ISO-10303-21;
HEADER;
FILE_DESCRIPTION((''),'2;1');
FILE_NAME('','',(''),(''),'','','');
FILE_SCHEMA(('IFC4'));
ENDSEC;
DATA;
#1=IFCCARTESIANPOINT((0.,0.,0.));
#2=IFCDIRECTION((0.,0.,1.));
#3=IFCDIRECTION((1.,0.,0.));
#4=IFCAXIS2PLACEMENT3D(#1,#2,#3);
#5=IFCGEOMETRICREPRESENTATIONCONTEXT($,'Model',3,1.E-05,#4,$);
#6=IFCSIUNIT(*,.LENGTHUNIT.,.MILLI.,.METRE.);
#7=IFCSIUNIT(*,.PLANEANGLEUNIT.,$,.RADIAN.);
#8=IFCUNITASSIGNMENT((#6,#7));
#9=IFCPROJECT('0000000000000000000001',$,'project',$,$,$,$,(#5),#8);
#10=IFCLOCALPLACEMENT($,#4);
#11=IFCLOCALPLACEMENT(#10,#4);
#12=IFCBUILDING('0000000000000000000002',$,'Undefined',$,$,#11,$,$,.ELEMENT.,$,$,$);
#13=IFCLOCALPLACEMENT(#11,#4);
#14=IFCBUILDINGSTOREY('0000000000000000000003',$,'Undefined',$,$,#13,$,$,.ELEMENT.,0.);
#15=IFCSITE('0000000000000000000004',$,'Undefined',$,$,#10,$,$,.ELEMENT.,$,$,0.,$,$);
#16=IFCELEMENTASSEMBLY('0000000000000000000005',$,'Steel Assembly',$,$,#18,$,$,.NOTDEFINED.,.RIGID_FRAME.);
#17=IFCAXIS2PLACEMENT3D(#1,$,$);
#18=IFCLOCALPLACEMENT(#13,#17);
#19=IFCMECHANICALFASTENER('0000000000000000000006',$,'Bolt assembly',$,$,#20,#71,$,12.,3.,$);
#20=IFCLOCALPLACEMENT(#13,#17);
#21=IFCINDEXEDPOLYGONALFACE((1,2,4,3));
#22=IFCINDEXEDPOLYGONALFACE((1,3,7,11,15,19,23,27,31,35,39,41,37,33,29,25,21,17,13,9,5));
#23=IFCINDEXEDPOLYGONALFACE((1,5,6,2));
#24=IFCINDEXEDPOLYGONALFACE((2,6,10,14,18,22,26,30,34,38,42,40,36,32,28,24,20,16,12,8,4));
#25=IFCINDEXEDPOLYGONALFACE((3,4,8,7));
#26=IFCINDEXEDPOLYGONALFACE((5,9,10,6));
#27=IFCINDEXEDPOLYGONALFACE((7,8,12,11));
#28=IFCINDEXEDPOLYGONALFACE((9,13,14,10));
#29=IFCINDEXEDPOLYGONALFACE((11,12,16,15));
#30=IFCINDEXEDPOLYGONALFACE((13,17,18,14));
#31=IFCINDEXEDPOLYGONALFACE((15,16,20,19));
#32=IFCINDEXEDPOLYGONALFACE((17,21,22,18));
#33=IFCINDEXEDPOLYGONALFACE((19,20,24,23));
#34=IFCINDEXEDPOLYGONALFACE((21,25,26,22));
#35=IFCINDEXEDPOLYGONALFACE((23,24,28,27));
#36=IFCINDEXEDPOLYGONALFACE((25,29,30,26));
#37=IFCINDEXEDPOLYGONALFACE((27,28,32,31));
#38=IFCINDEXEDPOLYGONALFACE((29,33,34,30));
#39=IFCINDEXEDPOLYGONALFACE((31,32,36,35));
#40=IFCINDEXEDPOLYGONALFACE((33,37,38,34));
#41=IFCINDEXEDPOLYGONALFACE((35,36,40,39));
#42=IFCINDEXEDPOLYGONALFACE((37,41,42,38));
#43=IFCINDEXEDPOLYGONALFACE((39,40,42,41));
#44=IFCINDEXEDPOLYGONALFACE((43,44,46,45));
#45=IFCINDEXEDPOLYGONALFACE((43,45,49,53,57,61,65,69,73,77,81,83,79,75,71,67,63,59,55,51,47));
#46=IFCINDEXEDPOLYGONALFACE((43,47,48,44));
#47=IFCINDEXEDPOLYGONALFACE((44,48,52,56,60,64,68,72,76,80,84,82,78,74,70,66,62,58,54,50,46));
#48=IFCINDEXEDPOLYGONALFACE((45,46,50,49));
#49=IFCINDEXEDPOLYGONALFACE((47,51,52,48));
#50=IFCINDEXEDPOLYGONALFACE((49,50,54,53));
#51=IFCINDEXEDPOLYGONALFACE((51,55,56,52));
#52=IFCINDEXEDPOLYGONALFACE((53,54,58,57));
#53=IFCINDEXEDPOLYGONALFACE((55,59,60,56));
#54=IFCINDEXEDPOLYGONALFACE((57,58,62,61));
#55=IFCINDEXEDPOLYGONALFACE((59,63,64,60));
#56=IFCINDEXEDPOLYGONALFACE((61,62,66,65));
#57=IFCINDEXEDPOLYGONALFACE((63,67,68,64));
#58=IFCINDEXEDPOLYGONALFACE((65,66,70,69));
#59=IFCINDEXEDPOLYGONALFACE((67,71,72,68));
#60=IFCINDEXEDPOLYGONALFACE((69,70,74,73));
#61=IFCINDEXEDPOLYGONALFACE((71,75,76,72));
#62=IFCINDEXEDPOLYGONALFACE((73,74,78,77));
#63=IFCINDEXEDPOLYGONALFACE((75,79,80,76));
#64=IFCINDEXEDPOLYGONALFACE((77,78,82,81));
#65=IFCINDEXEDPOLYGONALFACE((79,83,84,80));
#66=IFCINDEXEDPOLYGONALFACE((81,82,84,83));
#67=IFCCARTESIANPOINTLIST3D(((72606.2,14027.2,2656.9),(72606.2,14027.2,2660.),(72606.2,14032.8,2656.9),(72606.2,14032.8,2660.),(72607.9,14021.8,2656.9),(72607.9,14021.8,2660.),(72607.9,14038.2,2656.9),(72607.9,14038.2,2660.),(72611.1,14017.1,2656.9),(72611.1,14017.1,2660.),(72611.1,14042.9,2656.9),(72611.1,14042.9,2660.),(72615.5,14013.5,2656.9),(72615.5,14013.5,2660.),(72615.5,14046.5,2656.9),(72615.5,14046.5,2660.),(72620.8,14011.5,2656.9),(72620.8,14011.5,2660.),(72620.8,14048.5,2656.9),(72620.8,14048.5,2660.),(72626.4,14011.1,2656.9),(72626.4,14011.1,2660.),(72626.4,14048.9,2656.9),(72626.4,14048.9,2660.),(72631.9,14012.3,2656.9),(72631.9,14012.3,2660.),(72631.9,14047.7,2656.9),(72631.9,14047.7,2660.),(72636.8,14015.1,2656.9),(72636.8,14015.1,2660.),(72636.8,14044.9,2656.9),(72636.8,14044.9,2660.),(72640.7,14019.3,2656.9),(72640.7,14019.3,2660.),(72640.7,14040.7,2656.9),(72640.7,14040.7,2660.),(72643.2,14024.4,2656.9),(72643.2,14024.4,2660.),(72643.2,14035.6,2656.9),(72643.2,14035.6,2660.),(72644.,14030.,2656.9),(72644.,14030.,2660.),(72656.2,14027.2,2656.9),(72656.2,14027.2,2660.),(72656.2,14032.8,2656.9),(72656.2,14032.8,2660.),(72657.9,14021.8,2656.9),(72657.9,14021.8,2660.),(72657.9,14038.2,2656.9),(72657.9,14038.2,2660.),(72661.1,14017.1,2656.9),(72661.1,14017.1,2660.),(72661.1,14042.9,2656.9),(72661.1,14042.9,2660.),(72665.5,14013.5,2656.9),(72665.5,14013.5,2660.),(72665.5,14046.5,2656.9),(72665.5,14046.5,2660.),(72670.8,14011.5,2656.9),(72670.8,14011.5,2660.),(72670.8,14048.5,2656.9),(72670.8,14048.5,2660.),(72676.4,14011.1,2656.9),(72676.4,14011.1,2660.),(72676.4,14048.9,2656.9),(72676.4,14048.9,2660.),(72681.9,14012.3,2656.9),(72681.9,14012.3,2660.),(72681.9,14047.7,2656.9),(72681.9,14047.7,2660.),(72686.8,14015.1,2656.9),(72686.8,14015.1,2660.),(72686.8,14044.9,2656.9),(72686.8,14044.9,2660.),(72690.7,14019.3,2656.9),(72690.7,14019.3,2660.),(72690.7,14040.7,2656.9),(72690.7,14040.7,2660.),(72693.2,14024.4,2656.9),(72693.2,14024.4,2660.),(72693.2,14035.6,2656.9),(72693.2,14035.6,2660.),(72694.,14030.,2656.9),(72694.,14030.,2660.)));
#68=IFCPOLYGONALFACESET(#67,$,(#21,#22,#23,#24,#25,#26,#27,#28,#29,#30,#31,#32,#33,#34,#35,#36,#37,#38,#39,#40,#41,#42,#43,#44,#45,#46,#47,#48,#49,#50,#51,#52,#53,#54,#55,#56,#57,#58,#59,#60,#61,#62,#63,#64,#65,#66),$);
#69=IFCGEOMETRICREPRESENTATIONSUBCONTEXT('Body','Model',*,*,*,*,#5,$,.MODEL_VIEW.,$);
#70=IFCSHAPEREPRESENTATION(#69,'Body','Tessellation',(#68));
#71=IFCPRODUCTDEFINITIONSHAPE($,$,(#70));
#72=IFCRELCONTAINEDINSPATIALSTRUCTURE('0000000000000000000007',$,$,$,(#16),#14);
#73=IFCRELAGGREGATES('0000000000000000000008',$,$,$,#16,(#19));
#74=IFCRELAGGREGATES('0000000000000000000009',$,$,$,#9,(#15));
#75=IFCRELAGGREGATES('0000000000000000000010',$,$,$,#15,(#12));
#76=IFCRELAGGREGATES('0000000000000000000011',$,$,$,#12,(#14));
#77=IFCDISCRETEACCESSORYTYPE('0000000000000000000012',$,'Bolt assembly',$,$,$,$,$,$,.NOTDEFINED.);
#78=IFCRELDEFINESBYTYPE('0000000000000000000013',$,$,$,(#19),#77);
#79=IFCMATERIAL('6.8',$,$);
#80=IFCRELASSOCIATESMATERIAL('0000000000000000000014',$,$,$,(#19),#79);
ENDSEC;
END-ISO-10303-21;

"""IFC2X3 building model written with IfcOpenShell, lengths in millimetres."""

from ifc_helpers import new_model, si_unit, frame, origin_with_axes, origin_2d_with_axis, place, context, subcontext, project, spatial, circle, extrude, source, transform, mapped, material, type_object, element, aggregate, save


model = new_model("IFC2X3")

# Units and contexts
model_context = context("Model", 3, precision=1e-05, world=origin_with_axes())
body_context = subcontext(model_context, "Body", "Model", "MODEL_VIEW")
ifc_project = project(units=[si_unit("LENGTHUNIT", "METRE", prefix="MILLI"), si_unit("PLANEANGLEUNIT", "RADIAN")], contexts=[model_context])

# Site, building, storey
site_placement = place(None, origin_with_axes())
site = spatial("IfcSite", under=ifc_project, at=site_placement, Name="Undefined", CompositionType="ELEMENT", RefElevation=0.0)
building_placement = place(site_placement, origin_with_axes())
building = spatial("IfcBuilding", under=site, at=building_placement, Name="Undefined", CompositionType="ELEMENT")
storey_placement = place(building_placement, origin_with_axes())
storey = spatial("IfcBuildingStorey", under=building, at=storey_placement, Name="Undefined", CompositionType="ELEMENT", Elevation=0.0)

# Element assembly
assembly_1_placement = place(storey_placement, origin_with_axes())
assembly_1 = element("IfcElementAssembly", 1, at=assembly_1_placement, inside=storey, Name="Steel Assembly", AssemblyPlace="NOTDEFINED", PredefinedType="RIGID_FRAME")

# Shared definitions
ifc_material_1 = material(Name="6.8")
discrete_accessory_type_1 = type_object("IfcDiscreteAccessoryType", Name="Bolt assembly")

# Mechanical fastener
shared_shape_1 = source(origin_with_axes(), body_context, "Body", "SweptSolid", [
    extrude(circle(Radius=19.0, at=origin_2d_with_axis()), frame((0.0, 0.0, 0.0), z_axis=(0.0, 1.0, 0.0), x_axis=(1.0, 0.0, 0.0)), (0.0, 0.0, 1.0), 3.1),
])
mechanical_fastener_1_placement = place(assembly_1_placement, frame((72625.0, 14030.0, 2660.0), z_axis=(0.0, 1.0, 0.0), x_axis=(1.0, 0.0, 0.0)))
mechanical_fastener_1 = element("IfcMechanicalFastener", 2, at=mechanical_fastener_1_placement, type_object=discrete_accessory_type_1, material=ifc_material_1, Name="Bolt assembly", NominalDiameter=12.0, NominalLength=3.0, context=body_context, shape_type="MappedRepresentation", body=[
    mapped(shared_shape_1, transform((0.0, 0.0, 0.0))),
    mapped(shared_shape_1, transform((50.0, 0.0, 0.0))),
])
aggregate(assembly_1, [mechanical_fastener_1])

save(model, "model.ifc")
